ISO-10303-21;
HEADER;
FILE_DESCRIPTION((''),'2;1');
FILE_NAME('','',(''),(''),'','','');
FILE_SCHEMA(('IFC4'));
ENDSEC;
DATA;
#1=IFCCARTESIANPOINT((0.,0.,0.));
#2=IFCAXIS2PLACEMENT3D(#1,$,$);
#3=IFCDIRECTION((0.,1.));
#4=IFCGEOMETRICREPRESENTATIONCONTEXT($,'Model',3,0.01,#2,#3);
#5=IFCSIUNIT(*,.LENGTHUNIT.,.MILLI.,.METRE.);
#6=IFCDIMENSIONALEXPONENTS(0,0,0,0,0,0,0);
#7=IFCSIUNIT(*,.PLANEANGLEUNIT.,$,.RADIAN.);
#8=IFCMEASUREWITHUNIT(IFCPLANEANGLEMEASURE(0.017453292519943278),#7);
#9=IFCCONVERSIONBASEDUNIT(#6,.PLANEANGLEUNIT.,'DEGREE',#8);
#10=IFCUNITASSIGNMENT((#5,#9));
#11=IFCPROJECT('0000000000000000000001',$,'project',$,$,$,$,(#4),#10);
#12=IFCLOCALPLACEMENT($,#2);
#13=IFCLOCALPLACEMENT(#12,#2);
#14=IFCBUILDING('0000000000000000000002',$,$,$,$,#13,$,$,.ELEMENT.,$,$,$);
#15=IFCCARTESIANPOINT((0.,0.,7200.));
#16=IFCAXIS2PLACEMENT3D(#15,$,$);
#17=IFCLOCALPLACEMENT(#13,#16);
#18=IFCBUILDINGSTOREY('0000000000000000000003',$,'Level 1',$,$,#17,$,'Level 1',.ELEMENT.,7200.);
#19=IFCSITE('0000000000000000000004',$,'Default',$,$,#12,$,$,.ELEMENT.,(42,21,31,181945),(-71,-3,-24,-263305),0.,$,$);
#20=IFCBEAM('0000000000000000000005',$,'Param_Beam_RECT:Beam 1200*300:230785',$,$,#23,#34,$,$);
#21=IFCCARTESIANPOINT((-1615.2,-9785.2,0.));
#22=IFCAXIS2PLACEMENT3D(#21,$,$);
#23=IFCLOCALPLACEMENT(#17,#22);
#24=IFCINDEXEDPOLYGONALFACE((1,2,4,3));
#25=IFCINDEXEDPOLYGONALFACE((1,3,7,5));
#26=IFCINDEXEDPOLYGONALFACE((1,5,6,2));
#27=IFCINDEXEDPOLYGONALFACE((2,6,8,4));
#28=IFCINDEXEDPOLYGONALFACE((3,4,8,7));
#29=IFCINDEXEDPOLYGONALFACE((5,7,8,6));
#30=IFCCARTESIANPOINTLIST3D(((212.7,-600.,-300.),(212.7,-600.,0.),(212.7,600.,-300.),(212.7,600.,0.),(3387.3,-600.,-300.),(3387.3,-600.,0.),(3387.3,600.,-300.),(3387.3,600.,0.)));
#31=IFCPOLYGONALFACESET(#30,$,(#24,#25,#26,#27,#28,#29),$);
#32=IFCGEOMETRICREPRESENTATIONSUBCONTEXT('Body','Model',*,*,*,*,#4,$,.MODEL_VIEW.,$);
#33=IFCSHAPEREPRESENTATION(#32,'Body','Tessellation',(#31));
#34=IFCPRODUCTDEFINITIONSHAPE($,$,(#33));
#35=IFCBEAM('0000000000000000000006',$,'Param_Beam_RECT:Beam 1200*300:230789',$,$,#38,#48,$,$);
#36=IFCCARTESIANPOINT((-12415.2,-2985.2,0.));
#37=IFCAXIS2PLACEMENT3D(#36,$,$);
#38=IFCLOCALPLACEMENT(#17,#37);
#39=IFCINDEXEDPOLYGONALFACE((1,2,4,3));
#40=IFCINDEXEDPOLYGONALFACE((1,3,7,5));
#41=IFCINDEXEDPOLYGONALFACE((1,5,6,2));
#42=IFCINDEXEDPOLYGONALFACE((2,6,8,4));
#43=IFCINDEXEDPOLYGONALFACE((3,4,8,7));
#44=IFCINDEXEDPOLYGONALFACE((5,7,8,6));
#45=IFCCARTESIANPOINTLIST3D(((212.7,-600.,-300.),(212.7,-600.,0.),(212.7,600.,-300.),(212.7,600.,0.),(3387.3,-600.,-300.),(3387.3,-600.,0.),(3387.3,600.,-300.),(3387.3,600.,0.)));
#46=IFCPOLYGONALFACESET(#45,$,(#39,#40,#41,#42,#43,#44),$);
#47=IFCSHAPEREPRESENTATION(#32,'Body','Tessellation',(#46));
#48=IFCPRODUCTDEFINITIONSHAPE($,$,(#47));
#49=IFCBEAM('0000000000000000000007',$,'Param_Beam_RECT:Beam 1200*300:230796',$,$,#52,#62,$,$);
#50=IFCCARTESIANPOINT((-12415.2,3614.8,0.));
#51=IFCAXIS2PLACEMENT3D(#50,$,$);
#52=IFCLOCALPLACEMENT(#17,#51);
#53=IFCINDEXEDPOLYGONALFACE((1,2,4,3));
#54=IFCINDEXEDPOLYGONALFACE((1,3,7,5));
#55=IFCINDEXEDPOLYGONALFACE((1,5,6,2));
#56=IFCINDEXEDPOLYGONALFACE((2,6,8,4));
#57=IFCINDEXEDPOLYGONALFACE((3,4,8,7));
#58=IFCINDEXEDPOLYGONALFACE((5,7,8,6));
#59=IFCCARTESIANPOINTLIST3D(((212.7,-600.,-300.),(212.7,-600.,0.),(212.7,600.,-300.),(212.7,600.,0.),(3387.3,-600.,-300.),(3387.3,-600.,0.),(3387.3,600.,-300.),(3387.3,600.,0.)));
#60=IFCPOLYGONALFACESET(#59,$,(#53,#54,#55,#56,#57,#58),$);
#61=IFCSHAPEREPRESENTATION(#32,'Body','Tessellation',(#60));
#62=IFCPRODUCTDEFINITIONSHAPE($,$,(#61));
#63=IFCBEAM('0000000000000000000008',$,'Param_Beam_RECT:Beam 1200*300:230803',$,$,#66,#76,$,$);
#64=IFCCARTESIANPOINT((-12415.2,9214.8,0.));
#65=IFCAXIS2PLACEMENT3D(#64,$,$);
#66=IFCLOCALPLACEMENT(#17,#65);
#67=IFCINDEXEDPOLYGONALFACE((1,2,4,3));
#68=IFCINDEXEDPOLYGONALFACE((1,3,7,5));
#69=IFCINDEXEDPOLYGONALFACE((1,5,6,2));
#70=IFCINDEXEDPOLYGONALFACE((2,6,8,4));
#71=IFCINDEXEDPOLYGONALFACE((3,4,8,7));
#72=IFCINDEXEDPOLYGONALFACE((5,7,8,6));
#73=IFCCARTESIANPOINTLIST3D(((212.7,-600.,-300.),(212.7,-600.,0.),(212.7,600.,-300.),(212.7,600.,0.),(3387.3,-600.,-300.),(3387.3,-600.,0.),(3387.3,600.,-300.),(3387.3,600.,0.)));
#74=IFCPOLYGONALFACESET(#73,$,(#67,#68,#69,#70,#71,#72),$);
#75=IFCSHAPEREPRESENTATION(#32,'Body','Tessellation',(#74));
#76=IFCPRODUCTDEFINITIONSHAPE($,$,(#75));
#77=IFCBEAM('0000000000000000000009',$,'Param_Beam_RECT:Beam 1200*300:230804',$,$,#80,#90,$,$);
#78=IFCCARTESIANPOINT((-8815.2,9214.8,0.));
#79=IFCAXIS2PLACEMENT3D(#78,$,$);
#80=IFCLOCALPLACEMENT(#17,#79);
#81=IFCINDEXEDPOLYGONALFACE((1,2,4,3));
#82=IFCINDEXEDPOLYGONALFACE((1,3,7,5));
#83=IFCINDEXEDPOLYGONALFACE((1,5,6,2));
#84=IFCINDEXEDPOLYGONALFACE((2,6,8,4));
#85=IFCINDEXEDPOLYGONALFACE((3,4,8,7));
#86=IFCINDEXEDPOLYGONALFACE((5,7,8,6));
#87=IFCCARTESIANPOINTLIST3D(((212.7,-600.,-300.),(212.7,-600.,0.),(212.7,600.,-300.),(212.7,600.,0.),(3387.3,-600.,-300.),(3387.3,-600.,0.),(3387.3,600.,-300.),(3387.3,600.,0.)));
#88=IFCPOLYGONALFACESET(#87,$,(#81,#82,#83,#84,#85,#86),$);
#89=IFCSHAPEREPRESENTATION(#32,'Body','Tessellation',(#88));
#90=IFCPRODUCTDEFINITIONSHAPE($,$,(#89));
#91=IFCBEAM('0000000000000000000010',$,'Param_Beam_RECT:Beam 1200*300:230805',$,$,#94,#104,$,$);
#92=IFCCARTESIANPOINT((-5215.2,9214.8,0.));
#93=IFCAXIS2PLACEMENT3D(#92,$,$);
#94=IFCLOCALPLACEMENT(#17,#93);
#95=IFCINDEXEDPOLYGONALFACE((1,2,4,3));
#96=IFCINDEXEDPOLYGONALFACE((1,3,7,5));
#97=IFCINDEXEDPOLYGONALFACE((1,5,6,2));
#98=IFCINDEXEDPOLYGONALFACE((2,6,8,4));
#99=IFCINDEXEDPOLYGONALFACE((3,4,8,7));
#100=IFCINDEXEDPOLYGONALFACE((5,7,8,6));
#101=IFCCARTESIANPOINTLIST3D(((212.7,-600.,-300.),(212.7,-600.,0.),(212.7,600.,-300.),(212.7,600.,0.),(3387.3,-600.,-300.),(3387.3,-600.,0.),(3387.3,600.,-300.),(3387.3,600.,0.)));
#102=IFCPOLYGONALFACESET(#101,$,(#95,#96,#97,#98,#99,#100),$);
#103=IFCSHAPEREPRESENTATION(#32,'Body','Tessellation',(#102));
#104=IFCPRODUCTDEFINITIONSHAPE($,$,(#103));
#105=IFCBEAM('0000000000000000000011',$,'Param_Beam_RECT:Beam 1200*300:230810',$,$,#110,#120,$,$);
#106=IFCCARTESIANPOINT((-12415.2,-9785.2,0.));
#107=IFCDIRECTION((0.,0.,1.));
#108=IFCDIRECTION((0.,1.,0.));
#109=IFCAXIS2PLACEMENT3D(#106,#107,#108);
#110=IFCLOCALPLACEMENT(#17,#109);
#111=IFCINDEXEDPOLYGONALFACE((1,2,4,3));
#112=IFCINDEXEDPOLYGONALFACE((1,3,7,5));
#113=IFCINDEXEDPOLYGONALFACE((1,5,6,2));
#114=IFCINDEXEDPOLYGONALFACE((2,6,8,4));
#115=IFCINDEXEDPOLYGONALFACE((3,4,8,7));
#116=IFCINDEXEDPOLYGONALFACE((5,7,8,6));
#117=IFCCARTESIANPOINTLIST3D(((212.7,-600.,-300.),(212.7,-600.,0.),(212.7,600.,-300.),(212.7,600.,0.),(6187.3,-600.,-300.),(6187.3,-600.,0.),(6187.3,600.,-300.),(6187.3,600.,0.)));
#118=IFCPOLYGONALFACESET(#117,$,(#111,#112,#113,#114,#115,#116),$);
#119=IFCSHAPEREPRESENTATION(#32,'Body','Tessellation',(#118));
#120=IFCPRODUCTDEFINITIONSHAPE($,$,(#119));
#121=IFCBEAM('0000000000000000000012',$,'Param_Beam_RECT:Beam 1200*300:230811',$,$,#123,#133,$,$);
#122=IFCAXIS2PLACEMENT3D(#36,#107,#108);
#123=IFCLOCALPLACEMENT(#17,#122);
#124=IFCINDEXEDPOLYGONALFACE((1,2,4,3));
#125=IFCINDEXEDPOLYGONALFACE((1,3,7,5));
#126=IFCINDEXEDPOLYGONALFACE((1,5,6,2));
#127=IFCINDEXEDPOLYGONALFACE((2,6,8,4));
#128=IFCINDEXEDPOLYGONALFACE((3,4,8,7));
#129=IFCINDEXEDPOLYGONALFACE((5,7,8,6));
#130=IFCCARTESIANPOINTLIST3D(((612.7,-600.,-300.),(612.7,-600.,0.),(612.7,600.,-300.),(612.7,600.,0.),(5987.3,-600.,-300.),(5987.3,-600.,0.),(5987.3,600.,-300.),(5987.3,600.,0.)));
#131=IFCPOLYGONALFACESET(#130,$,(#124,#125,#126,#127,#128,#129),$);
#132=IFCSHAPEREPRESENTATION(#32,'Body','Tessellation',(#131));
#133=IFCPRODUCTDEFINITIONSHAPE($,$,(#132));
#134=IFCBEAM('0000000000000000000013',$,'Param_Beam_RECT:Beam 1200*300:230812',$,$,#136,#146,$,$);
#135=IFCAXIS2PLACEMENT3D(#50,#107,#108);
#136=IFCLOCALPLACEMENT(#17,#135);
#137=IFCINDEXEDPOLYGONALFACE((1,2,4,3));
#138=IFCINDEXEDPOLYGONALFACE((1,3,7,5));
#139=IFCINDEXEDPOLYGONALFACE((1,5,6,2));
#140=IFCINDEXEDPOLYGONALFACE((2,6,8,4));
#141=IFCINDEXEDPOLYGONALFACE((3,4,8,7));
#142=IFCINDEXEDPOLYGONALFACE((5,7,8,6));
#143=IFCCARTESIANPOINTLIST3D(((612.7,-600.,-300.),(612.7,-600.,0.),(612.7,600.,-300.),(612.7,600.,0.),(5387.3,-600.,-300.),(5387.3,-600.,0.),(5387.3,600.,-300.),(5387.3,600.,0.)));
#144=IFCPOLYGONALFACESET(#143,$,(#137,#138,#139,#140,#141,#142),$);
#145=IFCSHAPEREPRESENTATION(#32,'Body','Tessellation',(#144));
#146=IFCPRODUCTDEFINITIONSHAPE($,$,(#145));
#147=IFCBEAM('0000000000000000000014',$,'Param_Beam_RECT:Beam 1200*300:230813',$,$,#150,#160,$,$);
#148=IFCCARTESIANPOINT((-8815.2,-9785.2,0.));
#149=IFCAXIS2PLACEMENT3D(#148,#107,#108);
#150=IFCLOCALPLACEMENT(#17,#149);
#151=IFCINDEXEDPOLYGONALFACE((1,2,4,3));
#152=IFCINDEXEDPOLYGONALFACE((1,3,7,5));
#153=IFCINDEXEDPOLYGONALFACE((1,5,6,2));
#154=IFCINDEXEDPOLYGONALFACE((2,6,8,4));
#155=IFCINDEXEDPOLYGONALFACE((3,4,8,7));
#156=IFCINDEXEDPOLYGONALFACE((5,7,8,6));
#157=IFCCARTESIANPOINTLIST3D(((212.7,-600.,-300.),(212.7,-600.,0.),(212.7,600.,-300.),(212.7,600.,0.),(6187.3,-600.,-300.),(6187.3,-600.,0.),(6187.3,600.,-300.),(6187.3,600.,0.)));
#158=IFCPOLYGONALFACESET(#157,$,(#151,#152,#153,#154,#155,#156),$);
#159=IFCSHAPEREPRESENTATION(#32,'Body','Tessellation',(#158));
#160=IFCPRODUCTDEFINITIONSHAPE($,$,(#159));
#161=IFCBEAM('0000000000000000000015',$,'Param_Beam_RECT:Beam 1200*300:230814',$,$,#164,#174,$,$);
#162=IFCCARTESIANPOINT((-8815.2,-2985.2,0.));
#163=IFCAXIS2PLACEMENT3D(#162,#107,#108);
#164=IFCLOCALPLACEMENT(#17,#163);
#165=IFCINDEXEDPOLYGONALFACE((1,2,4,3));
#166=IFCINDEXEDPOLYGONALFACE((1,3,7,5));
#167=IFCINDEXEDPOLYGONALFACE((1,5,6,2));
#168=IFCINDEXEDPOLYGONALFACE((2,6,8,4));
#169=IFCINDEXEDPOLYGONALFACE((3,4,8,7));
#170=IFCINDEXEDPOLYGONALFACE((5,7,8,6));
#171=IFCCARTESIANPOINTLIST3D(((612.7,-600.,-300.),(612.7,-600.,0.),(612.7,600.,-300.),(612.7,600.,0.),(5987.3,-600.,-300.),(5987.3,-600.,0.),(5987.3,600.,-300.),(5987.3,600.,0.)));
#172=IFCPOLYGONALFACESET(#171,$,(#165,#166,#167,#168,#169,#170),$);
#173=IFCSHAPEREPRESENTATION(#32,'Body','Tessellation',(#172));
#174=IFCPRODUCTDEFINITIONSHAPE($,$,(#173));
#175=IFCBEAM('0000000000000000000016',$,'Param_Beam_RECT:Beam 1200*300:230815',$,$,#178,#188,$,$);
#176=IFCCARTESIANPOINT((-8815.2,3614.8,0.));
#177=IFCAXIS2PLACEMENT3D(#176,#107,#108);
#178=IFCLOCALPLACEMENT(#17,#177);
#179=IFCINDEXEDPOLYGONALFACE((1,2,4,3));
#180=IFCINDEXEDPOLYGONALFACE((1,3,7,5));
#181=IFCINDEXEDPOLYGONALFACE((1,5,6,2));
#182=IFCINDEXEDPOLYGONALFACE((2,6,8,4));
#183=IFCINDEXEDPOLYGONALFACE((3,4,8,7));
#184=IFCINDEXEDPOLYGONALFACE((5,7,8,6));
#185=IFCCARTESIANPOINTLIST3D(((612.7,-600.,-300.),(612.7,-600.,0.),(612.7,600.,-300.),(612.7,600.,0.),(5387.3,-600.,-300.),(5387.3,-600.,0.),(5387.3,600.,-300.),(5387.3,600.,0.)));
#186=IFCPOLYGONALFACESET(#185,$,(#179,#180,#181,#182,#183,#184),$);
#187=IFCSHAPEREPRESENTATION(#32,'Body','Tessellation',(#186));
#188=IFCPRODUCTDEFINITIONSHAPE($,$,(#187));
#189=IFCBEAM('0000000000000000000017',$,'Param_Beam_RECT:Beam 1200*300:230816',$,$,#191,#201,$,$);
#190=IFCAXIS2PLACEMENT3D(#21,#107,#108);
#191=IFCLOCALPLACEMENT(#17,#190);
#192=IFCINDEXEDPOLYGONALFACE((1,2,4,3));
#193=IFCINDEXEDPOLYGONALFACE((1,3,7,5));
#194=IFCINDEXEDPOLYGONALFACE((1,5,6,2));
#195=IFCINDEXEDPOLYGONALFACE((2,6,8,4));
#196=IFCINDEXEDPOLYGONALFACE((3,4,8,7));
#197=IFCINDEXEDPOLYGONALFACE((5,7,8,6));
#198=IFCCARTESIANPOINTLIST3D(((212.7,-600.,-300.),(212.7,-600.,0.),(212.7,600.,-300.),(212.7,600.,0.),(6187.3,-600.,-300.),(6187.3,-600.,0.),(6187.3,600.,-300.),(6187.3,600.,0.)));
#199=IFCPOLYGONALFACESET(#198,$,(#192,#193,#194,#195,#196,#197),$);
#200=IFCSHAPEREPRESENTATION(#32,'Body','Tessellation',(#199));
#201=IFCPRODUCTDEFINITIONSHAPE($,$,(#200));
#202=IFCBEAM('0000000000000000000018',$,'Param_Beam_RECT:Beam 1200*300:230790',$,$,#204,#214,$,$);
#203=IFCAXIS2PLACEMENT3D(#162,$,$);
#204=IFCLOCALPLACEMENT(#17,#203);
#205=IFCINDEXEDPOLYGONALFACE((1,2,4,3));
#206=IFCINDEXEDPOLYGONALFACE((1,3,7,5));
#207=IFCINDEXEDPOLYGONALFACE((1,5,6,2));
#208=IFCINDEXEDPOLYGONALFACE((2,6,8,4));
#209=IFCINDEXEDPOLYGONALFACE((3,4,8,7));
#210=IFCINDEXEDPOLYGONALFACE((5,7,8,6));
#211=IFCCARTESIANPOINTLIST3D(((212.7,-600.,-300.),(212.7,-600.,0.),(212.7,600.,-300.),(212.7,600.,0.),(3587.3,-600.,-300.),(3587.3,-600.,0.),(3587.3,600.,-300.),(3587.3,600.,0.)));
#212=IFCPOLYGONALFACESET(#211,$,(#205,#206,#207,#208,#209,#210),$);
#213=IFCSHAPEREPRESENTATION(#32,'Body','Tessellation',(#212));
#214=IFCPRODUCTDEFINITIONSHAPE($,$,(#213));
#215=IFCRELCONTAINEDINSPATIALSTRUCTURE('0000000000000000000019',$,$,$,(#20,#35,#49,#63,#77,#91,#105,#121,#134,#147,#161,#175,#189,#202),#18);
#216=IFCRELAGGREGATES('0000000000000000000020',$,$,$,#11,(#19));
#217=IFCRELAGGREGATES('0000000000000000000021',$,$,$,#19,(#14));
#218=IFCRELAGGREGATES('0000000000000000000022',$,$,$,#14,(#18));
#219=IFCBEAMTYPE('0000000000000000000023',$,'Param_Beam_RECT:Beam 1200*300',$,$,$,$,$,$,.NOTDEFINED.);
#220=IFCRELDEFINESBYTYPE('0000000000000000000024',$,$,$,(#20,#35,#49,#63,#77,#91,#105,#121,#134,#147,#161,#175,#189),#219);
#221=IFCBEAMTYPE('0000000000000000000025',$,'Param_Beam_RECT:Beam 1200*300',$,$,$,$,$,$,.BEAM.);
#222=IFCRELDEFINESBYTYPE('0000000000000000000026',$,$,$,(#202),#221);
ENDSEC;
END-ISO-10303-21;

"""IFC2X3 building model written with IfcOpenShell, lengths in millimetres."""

from ifc_helpers import new_model, entity, si_unit, converted_unit, direction, frame, frame_2d, origin, origin_2d_with_axis, place, context, subcontext, project, spatial, rectangle, extrude, type_object, element, save


model = new_model("IFC2X3")

# Units and contexts
model_context = context("Model", 3, precision=0.01, world=origin(), true_north=direction((0.0, 1.0)))
body_context = subcontext(model_context, "Body", "Model", "MODEL_VIEW")
ifc_project = project(units=[si_unit("LENGTHUNIT", "METRE", prefix="MILLI"), converted_unit("PLANEANGLEUNIT", "DEGREE", entity("IfcPlaneAngleMeasure", 0.017453292519943278), si_unit("PLANEANGLEUNIT", "RADIAN"), dimensions=[0, 0, 0, 0, 0, 0, 0])], contexts=[model_context])

# Site, building, storey
site_placement = place(None, origin())
site = spatial("IfcSite", under=ifc_project, at=site_placement, Name="Default", CompositionType="ELEMENT", RefLatitude=(42, 21, 31, 181945), RefLongitude=(-71, -3, -24, -263305), RefElevation=0.0)
building_placement = place(site_placement, origin())
building = spatial("IfcBuilding", under=site, at=building_placement, CompositionType="ELEMENT")
storey_placement = place(building_placement, frame((0.0, 0.0, 7200.0)))
storey = spatial("IfcBuildingStorey", under=building, at=storey_placement, Name="Level 1", LongName="Level 1", CompositionType="ELEMENT", Elevation=7200.0)

# Beams
beam_type_1 = type_object("IfcBeamType", Name="Param_Beam_RECT:Beam 1200*300", PredefinedType="NOTDEFINED")
beam_1_placement = place(storey_placement, frame((-1615.2, -9785.2, 0.0)))
element("IfcBeam", 1, at=beam_1_placement, inside=storey, type_object=beam_type_1, Name="Param_Beam_RECT:Beam 1200*300:230785", context=body_context, shape_type="SweptSolid", body=[
    extrude(rectangle(XDim=300.0, YDim=1200.0, at=origin_2d_with_axis()), frame((212.7, 0.0, -150.0), z_axis=(1.0, 0.0, 0.0), x_axis=(0.0, 0.0, -1.0)), (0.0, 0.0, 1.0), 3174.6),
])
beam_2_placement = place(storey_placement, frame((-12415.2, -2985.2, 0.0)))
element("IfcBeam", 2, at=beam_2_placement, inside=storey, type_object=beam_type_1, Name="Param_Beam_RECT:Beam 1200*300:230789", context=body_context, shape_type="SweptSolid", body=[
    extrude(rectangle(XDim=300.0, YDim=1200.0, at=frame_2d((0.0, 0.0), x_axis=(1.0, 0.0))), frame((212.7, 0.0, -150.0), z_axis=(1.0, 0.0, 0.0), x_axis=(0.0, 0.0, -1.0)), (0.0, 0.0, 1.0), 3174.6),
])
beam_3_placement = place(storey_placement, frame((-12415.2, 3614.8, 0.0)))
element("IfcBeam", 3, at=beam_3_placement, inside=storey, type_object=beam_type_1, Name="Param_Beam_RECT:Beam 1200*300:230796", context=body_context, shape_type="SweptSolid", body=[
    extrude(rectangle(XDim=300.0, YDim=1200.0, at=origin_2d_with_axis()), frame((212.7, 0.0, -150.0), z_axis=(1.0, 0.0, 0.0), x_axis=(0.0, 0.0, -1.0)), (0.0, 0.0, 1.0), 3174.6),
])
beam_4_placement = place(storey_placement, frame((-12415.2, 9214.8, 0.0)))
element("IfcBeam", 4, at=beam_4_placement, inside=storey, type_object=beam_type_1, Name="Param_Beam_RECT:Beam 1200*300:230803", context=body_context, shape_type="SweptSolid", body=[
    extrude(rectangle(XDim=300.0, YDim=1200.0, at=frame_2d((0.0, 0.0), x_axis=(1.0, 0.0))), frame((212.7, 0.0, -150.0), z_axis=(1.0, 0.0, 0.0), x_axis=(0.0, 0.0, -1.0)), (0.0, 0.0, 1.0), 3174.6),
])
for number, where, name in (
    (5, (-8815.2, 9214.8, 0.0), "Param_Beam_RECT:Beam 1200*300:230804"),
    (6, (-5215.2, 9214.8, 0.0), "Param_Beam_RECT:Beam 1200*300:230805"),
):
    element("IfcBeam", number, at=place(storey_placement, frame(where)), inside=storey, type_object=beam_type_1, Name=name, context=body_context, shape_type="SweptSolid", body=[
        extrude(rectangle(XDim=300.0, YDim=1200.0, at=frame_2d((0.0, 0.0), x_axis=(1.0, 0.0))), frame((212.7, 0.0, -150.0), z_axis=(1.0, 0.0, 0.0), x_axis=(0.0, 0.0, -1.0)), (0.0, 0.0, 1.0), 3174.6),
    ])
beam_5_placement = place(storey_placement, frame((-12415.2, -9785.2, 0.0), z_axis=(0.0, 0.0, 1.0), x_axis=(0.0, 1.0, 0.0)))
element("IfcBeam", 7, at=beam_5_placement, inside=storey, type_object=beam_type_1, Name="Param_Beam_RECT:Beam 1200*300:230810", context=body_context, shape_type="SweptSolid", body=[
    extrude(rectangle(XDim=300.0, YDim=1200.0, at=origin_2d_with_axis()), frame((212.7, 0.0, -150.0), z_axis=(1.0, 0.0, 0.0), x_axis=(0.0, 0.0, -1.0)), (0.0, 0.0, 1.0), 5974.6),
])
beam_6_placement = place(storey_placement, frame((-12415.2, -2985.2, 0.0), z_axis=(0.0, 0.0, 1.0), x_axis=(0.0, 1.0, 0.0)))
element("IfcBeam", 8, at=beam_6_placement, inside=storey, type_object=beam_type_1, Name="Param_Beam_RECT:Beam 1200*300:230811", context=body_context, shape_type="SweptSolid", body=[
    extrude(rectangle(XDim=300.0, YDim=1200.0, at=frame_2d((0.0, 0.0), x_axis=(1.0, 0.0))), frame((612.7, 0.0, -150.0), z_axis=(1.0, 0.0, 0.0), x_axis=(0.0, 0.0, -1.0)), (0.0, 0.0, 1.0), 5374.6),
])
beam_7_placement = place(storey_placement, frame((-12415.2, 3614.8, 0.0), z_axis=(0.0, 0.0, 1.0), x_axis=(0.0, 1.0, 0.0)))
element("IfcBeam", 9, at=beam_7_placement, inside=storey, type_object=beam_type_1, Name="Param_Beam_RECT:Beam 1200*300:230812", context=body_context, shape_type="SweptSolid", body=[
    extrude(rectangle(XDim=300.0, YDim=1200.0, at=origin_2d_with_axis()), frame((612.7, 0.0, -150.0), z_axis=(1.0, 0.0, 0.0), x_axis=(0.0, 0.0, -1.0)), (0.0, 0.0, 1.0), 4774.6),
])
beam_8_placement = place(storey_placement, frame((-8815.2, -9785.2, 0.0), z_axis=(0.0, 0.0, 1.0), x_axis=(0.0, 1.0, 0.0)))
element("IfcBeam", 10, at=beam_8_placement, inside=storey, type_object=beam_type_1, Name="Param_Beam_RECT:Beam 1200*300:230813", context=body_context, shape_type="SweptSolid", body=[
    extrude(rectangle(XDim=300.0, YDim=1200.0, at=frame_2d((0.0, 0.0), x_axis=(1.0, 0.0))), frame((212.7, 0.0, -150.0), z_axis=(1.0, 0.0, 0.0), x_axis=(0.0, 0.0, -1.0)), (0.0, 0.0, 1.0), 5974.6),
])
beam_9_placement = place(storey_placement, frame((-8815.2, -2985.2, 0.0), z_axis=(0.0, 0.0, 1.0), x_axis=(0.0, 1.0, 0.0)))
element("IfcBeam", 11, at=beam_9_placement, inside=storey, type_object=beam_type_1, Name="Param_Beam_RECT:Beam 1200*300:230814", context=body_context, shape_type="SweptSolid", body=[
    extrude(rectangle(XDim=300.0, YDim=1200.0, at=frame_2d((0.0, 0.0), x_axis=(1.0, 0.0))), frame((612.7, 0.0, -150.0), z_axis=(1.0, 0.0, 0.0), x_axis=(0.0, 0.0, -1.0)), (0.0, 0.0, 1.0), 5374.6),
])
beam_10_placement = place(storey_placement, frame((-8815.2, 3614.8, 0.0), z_axis=(0.0, 0.0, 1.0), x_axis=(0.0, 1.0, 0.0)))
element("IfcBeam", 12, at=beam_10_placement, inside=storey, type_object=beam_type_1, Name="Param_Beam_RECT:Beam 1200*300:230815", context=body_context, shape_type="SweptSolid", body=[
    extrude(rectangle(XDim=300.0, YDim=1200.0, at=frame_2d((0.0, 0.0), x_axis=(1.0, 0.0))), frame((612.7, 0.0, -150.0), z_axis=(1.0, 0.0, 0.0), x_axis=(0.0, 0.0, -1.0)), (0.0, 0.0, 1.0), 4774.6),
])
beam_11_placement = place(storey_placement, frame((-1615.2, -9785.2, 0.0), z_axis=(0.0, 0.0, 1.0), x_axis=(0.0, 1.0, 0.0)))
element("IfcBeam", 13, at=beam_11_placement, inside=storey, type_object=beam_type_1, Name="Param_Beam_RECT:Beam 1200*300:230816", context=body_context, shape_type="SweptSolid", body=[
    extrude(rectangle(XDim=300.0, YDim=1200.0, at=frame_2d((0.0, 0.0), x_axis=(1.0, 0.0))), frame((212.7, 0.0, -150.0), z_axis=(1.0, 0.0, 0.0), x_axis=(0.0, 0.0, -1.0)), (0.0, 0.0, 1.0), 5974.6),
])
beam_type_2 = type_object("IfcBeamType", Name="Param_Beam_RECT:Beam 1200*300", PredefinedType="BEAM")
beam_12_placement = place(storey_placement, frame((-8815.2, -2985.2, 0.0)))
element("IfcBeam", 14, at=beam_12_placement, inside=storey, type_object=beam_type_2, Name="Param_Beam_RECT:Beam 1200*300:230790", context=body_context, shape_type="SweptSolid", body=[
    extrude(rectangle(XDim=300.0, YDim=1200.0, at=frame_2d((0.0, 0.0), x_axis=(1.0, 0.0))), frame((212.7, 0.0, -150.0), z_axis=(1.0, 0.0, 0.0), x_axis=(0.0, 0.0, -1.0)), (0.0, 0.0, 1.0), 3374.6),
])

save(model, "model.ifc")
